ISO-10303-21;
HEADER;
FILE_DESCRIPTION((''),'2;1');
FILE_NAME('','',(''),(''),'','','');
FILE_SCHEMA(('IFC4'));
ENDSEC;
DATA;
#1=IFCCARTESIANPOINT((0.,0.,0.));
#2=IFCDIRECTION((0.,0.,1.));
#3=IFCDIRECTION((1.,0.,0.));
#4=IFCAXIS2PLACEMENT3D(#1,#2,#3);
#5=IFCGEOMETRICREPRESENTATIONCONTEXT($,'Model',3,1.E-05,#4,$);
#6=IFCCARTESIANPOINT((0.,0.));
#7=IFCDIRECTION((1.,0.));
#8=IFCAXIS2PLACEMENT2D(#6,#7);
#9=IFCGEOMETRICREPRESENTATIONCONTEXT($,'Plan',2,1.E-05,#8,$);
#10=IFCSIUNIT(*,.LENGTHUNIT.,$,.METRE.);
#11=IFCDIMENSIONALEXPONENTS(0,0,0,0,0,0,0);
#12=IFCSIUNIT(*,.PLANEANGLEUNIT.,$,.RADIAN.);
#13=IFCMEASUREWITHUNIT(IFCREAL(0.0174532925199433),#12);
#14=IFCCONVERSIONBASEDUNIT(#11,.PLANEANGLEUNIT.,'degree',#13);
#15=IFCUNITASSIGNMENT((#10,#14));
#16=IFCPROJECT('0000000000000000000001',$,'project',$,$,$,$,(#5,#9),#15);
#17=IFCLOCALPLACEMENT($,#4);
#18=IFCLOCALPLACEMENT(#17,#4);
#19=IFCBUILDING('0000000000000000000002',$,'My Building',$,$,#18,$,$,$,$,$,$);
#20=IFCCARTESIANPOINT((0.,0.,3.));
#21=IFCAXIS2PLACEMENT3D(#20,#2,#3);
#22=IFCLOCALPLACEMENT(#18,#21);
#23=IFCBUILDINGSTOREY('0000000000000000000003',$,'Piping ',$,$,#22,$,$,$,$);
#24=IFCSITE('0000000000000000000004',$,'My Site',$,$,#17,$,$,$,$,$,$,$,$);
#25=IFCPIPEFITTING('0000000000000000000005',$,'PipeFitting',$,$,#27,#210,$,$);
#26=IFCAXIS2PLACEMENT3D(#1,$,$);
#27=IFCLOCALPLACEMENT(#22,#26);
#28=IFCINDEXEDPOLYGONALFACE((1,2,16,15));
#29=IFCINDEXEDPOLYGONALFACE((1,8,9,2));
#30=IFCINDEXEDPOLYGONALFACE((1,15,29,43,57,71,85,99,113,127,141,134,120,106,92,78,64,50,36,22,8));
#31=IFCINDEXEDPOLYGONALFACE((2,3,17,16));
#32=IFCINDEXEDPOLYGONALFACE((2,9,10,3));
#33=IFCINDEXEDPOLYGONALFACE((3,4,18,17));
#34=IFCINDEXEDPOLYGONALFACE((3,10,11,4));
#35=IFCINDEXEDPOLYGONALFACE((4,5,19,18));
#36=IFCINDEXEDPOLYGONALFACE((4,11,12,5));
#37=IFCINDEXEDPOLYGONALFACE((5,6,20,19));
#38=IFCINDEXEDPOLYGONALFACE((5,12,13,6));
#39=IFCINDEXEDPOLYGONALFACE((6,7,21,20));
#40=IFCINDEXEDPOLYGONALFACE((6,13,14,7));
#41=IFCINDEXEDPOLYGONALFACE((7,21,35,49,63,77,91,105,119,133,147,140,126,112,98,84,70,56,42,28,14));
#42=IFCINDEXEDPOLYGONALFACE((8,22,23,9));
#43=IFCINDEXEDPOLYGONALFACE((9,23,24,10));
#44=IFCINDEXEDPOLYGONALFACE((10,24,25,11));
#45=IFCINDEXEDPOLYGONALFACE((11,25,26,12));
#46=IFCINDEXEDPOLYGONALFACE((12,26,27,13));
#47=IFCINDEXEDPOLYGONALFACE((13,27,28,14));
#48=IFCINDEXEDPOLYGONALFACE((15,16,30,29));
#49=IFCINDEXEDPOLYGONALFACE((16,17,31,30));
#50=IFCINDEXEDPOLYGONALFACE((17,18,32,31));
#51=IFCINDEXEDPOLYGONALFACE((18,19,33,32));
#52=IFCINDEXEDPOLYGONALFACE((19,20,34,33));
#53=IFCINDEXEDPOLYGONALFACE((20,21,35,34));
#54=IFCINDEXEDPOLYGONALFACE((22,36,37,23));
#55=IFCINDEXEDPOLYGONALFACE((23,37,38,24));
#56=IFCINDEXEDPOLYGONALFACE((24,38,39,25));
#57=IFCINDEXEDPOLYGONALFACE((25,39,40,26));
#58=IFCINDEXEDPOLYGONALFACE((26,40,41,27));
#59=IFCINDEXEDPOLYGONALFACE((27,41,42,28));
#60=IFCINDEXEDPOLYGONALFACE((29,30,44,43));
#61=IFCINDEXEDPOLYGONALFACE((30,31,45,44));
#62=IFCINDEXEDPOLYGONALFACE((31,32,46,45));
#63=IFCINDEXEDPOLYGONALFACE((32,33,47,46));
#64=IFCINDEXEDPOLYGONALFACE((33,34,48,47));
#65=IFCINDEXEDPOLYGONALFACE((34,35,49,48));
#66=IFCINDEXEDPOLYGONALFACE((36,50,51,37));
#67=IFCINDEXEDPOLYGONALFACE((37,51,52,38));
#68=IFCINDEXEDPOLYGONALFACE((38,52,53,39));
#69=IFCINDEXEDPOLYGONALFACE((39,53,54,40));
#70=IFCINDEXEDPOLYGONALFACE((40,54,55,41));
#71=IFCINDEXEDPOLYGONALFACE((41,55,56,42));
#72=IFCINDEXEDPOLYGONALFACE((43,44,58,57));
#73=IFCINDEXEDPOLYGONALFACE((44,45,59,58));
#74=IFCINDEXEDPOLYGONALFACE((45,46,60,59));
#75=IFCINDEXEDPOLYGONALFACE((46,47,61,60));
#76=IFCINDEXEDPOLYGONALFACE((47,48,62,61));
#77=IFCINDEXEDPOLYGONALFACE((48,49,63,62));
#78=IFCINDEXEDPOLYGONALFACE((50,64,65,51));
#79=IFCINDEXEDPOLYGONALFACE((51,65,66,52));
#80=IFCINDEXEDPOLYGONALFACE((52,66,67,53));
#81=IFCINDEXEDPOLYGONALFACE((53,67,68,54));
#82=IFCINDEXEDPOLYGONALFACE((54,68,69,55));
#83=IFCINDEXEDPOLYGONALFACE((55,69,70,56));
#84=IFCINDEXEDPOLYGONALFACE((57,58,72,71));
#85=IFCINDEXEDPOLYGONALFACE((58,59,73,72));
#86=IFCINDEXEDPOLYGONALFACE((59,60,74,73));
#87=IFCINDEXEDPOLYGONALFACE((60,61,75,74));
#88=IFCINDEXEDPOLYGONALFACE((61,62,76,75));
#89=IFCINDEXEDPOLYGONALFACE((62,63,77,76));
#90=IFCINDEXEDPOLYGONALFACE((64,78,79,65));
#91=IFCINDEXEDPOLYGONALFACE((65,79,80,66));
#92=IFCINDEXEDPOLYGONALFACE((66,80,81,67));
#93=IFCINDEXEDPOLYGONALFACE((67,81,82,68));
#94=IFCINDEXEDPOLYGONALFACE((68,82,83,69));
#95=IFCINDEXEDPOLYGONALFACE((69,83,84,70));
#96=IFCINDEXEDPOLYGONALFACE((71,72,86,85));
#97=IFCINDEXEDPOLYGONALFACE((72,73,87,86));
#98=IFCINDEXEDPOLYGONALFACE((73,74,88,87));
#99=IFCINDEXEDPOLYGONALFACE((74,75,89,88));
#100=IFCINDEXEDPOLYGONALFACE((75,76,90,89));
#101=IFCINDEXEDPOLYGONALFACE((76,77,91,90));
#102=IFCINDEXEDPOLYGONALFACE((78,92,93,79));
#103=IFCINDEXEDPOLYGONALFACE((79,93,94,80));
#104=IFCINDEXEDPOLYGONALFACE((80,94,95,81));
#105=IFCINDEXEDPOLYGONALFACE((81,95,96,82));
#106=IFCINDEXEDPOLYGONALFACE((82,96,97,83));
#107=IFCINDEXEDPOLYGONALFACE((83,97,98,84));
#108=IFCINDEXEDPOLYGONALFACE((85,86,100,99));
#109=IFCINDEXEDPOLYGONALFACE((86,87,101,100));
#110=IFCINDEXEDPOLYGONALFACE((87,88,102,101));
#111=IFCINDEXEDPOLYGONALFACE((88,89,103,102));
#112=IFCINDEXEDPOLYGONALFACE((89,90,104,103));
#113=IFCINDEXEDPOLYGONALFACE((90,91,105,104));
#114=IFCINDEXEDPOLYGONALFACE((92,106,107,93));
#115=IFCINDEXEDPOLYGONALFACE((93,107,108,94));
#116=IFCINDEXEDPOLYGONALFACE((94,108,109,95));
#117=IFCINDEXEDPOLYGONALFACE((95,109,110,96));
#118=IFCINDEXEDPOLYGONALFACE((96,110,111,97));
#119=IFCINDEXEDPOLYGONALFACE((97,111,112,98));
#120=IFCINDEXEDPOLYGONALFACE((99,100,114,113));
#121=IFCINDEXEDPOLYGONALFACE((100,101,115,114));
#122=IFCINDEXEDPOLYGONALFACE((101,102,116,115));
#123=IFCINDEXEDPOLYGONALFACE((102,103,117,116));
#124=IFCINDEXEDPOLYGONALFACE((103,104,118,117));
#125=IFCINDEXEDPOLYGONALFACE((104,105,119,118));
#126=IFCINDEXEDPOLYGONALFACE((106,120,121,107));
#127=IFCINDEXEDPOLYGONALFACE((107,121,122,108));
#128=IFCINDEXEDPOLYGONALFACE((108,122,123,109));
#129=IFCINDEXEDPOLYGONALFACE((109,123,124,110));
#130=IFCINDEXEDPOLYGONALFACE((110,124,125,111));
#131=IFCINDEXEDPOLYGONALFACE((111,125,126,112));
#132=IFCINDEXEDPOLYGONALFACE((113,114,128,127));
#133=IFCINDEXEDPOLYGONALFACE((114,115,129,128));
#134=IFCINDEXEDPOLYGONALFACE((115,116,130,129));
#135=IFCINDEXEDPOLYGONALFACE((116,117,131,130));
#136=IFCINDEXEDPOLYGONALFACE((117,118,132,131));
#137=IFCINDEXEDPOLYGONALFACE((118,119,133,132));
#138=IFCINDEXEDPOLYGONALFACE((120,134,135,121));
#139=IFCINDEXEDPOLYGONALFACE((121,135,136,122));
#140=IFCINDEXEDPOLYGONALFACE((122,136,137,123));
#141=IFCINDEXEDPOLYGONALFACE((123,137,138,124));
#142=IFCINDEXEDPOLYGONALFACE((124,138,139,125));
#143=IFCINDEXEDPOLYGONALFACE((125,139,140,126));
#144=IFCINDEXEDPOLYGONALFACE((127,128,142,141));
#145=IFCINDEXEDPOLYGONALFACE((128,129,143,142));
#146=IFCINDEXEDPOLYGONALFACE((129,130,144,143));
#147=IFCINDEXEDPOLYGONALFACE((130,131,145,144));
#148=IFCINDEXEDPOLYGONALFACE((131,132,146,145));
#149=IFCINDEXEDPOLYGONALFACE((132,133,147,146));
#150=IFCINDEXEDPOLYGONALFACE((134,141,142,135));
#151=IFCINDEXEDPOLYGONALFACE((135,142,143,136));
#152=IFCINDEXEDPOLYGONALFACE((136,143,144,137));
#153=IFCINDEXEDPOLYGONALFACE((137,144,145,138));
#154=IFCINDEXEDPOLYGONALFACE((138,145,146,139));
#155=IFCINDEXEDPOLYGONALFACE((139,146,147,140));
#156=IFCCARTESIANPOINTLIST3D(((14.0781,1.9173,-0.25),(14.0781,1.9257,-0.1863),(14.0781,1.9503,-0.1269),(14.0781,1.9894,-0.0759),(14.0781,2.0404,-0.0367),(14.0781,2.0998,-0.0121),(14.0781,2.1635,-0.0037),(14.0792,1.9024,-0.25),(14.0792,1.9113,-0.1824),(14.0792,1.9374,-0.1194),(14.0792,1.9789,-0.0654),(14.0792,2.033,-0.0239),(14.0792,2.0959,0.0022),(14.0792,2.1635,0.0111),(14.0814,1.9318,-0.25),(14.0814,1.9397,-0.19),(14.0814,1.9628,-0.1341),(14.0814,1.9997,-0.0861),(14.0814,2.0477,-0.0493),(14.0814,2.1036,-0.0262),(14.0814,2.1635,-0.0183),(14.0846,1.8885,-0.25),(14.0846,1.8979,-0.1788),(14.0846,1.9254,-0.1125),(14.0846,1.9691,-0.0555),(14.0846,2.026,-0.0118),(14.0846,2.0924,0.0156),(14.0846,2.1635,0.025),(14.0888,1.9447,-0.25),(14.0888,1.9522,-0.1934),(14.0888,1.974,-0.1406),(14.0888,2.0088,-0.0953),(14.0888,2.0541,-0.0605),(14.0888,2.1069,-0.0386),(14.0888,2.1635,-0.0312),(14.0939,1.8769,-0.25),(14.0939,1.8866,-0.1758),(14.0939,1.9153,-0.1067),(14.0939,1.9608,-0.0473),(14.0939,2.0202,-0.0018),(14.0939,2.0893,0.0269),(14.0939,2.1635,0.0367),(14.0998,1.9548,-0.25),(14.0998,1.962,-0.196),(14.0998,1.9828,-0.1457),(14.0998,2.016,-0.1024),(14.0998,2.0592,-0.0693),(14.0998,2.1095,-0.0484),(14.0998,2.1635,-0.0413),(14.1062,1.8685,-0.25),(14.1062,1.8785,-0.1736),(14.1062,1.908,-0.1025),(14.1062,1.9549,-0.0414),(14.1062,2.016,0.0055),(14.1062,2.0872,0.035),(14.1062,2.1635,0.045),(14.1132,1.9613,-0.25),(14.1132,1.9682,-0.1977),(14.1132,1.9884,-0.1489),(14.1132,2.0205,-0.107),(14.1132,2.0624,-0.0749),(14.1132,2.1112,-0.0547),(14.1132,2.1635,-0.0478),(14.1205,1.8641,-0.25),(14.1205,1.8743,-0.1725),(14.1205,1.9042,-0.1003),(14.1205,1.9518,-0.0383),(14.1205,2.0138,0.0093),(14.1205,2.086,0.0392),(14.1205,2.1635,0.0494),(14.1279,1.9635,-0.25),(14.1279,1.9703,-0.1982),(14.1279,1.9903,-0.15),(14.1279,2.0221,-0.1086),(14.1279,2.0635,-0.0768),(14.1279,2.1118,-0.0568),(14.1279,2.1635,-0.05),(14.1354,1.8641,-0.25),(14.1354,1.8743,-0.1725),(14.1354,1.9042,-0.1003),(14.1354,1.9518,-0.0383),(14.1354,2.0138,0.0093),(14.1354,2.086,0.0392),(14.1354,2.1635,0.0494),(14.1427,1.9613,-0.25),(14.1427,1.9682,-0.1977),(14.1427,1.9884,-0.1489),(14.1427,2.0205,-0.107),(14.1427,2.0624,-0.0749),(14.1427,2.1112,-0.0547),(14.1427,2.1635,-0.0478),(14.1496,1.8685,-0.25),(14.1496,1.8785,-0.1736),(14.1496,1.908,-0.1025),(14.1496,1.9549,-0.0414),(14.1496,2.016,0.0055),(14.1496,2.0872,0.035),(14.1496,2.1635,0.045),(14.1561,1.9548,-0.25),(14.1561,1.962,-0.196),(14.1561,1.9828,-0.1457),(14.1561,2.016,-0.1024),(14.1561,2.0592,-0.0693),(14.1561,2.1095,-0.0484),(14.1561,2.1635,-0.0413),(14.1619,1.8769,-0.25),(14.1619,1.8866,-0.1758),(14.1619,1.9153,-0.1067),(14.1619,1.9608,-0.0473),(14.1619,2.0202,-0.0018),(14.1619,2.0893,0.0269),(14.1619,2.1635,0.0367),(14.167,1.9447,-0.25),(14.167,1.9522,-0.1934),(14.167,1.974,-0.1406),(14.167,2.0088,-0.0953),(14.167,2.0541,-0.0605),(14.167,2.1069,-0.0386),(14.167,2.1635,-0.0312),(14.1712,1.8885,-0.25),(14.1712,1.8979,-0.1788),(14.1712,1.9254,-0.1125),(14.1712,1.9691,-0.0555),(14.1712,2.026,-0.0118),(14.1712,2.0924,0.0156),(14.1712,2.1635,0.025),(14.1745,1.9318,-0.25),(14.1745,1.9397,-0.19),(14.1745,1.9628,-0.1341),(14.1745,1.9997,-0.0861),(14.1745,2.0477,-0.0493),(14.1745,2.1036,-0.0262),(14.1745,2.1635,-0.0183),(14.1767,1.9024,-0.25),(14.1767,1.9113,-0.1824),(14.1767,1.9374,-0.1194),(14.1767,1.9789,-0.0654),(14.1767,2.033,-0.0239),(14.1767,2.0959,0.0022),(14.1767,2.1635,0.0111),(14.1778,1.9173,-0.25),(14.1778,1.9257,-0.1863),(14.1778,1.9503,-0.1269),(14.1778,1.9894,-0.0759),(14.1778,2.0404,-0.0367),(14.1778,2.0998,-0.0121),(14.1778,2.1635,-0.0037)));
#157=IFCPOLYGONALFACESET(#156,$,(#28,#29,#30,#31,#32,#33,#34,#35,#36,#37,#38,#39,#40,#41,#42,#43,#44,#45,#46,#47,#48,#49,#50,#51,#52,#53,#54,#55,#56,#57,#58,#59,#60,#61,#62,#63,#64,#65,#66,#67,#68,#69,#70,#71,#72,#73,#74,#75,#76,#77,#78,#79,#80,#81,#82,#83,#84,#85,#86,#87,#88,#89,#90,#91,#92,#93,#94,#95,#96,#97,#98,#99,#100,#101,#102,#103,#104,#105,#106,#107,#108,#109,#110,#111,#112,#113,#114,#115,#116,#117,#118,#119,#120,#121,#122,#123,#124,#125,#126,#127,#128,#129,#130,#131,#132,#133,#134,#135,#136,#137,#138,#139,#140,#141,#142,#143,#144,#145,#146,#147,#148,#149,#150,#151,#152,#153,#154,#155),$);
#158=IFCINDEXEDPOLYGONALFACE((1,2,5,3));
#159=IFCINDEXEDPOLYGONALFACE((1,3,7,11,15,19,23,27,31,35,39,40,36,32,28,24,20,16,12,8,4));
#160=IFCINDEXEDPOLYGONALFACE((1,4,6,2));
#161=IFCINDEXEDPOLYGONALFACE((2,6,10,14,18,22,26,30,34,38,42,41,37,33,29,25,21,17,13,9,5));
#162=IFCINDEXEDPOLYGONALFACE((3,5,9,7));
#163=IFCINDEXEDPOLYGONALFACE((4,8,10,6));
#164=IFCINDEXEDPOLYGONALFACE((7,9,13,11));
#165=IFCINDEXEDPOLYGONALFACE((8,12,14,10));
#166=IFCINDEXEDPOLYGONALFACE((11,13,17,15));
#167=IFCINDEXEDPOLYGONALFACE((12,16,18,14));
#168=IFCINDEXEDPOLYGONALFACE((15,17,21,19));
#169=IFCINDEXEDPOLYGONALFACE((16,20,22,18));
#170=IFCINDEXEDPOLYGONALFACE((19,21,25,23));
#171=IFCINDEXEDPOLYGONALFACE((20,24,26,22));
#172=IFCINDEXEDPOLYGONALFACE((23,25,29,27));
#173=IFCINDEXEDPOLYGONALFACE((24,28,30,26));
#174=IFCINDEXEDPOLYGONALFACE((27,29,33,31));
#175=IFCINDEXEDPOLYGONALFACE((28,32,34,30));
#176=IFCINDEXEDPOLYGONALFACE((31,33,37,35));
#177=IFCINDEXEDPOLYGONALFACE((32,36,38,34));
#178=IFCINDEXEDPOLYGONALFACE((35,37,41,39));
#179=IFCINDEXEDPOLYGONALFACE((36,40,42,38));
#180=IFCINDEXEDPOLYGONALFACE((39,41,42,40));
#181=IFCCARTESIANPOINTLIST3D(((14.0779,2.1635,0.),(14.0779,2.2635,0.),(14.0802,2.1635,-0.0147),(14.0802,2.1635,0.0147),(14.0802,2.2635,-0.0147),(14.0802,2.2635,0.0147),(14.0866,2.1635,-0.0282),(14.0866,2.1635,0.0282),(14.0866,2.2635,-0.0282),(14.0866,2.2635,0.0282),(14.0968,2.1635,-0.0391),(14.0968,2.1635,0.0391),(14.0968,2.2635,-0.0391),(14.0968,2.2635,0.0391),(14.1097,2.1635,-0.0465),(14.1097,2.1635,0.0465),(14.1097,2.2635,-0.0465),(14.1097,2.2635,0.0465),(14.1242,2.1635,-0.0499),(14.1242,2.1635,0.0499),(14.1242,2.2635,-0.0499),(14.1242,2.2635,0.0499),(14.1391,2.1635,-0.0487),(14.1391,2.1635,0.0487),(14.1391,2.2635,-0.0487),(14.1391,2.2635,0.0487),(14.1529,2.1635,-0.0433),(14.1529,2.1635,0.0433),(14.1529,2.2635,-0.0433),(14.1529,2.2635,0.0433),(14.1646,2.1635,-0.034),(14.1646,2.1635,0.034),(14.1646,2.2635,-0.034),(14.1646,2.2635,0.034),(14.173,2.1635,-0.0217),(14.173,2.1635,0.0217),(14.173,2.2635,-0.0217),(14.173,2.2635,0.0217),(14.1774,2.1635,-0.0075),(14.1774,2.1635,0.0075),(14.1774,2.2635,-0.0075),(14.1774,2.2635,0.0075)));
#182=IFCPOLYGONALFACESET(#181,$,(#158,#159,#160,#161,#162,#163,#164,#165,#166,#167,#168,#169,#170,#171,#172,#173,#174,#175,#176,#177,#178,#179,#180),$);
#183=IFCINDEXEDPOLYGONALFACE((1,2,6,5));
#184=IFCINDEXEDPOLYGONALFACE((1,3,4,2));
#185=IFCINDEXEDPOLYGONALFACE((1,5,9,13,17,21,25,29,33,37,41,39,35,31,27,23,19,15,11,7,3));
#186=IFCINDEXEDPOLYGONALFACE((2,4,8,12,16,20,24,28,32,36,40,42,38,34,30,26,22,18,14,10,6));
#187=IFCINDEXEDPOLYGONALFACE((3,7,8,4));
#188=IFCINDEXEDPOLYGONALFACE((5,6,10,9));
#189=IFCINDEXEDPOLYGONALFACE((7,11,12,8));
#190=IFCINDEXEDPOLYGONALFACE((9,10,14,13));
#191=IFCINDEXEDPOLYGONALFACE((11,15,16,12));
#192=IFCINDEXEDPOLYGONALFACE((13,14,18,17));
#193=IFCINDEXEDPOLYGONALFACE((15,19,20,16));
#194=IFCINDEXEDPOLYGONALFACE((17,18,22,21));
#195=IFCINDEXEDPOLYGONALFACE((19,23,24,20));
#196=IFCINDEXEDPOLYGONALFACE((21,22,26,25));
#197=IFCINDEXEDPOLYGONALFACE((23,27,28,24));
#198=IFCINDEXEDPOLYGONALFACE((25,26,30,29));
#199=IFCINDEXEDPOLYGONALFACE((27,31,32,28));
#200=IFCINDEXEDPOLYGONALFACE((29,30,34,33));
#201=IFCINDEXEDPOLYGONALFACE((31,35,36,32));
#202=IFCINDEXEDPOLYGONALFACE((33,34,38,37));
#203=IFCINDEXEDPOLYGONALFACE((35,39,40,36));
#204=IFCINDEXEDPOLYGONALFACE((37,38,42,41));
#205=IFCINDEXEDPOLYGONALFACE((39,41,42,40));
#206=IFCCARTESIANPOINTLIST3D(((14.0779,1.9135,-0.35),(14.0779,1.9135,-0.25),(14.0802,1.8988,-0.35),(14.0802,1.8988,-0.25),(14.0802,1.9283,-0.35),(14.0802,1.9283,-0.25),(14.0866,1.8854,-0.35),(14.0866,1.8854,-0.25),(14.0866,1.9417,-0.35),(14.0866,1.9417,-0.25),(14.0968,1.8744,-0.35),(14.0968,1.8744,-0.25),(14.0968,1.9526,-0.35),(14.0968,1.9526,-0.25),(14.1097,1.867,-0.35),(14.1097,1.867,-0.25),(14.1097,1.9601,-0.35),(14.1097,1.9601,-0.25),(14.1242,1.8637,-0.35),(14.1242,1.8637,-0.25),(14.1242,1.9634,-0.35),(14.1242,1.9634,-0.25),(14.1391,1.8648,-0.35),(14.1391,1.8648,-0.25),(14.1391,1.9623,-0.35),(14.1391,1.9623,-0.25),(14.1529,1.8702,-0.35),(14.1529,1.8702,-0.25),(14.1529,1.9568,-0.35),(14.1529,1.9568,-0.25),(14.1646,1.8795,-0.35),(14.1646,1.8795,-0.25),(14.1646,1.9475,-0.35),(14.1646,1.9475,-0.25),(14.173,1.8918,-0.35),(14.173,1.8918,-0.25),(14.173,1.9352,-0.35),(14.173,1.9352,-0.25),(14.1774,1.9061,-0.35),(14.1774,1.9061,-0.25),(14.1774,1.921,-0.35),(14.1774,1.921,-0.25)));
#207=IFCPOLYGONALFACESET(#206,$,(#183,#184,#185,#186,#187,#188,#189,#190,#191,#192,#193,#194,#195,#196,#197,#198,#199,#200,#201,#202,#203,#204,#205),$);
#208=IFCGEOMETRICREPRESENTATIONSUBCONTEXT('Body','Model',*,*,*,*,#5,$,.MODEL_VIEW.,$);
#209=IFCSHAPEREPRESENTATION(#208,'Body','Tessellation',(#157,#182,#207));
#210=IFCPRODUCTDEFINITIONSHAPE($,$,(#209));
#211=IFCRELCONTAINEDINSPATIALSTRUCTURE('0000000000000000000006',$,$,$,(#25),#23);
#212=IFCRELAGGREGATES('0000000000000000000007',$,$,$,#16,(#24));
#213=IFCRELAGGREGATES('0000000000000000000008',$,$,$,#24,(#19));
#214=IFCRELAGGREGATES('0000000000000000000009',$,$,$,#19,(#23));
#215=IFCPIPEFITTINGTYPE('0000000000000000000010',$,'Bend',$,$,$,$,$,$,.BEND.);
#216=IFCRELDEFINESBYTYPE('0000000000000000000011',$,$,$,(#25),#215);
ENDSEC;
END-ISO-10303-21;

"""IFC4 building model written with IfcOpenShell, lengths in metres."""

from ifc_helpers import new_model, entity, si_unit, converted_unit, frame, origin_with_axes, origin_2d_with_axis, place, context, subcontext, project, spatial, circle, extrude, source, transform, mapped, type_object, type_shapes, element, save


model = new_model("IFC4")

# Units and contexts
model_context = context("Model", 3, precision=1e-05, world=origin_with_axes())
plan_context = context("Plan", 2, precision=1e-05, world=origin_2d_with_axis())
body_context = subcontext(model_context, "Body", "Model", "MODEL_VIEW")
ifc_project = project(units=[si_unit("LENGTHUNIT", "METRE"), converted_unit("PLANEANGLEUNIT", "degree", entity("IfcReal", 0.0174532925199433), si_unit("PLANEANGLEUNIT", "RADIAN"), dimensions=[0, 0, 0, 0, 0, 0, 0])], contexts=[model_context, plan_context])

# Site, building, storey
site_placement = place(None, origin_with_axes())
site = spatial("IfcSite", under=ifc_project, at=site_placement, Name="My Site")
building_placement = place(site_placement, origin_with_axes())
building = spatial("IfcBuilding", under=site, at=building_placement, Name="My Building")
storey_placement = place(building_placement, frame((0.0, 0.0, 3.0), z_axis=(0.0, 0.0, 1.0), x_axis=(1.0, 0.0, 0.0)))
storey = spatial("IfcBuildingStorey", under=building, at=storey_placement, Name="Piping ")

# Pipe fitting
pipe_fitting_type = type_object("IfcPipeFittingType", Name="Bend", PredefinedType="BEND")
shared_shape = source(origin_with_axes(), body_context, "Body", "SolidModel", [
    entity("IfcSweptDiskSolid", entity("IfcIndexedPolyCurve", entity("IfcCartesianPointList3D", [[0.0, 0.0, -0.1], [0.0, -0.0732, -0.2768], [0.0, -0.25, -0.35]]), [entity("IfcArcIndex", [1, 2, 3])]), 0.05),
    extrude(circle(Radius=0.05), origin_with_axes(), (0.0, 0.0, -1.0), 0.1),
    extrude(circle(Radius=0.05), frame((0.0, -0.25, -0.35), z_axis=(0.0, -1.0, 0.0), x_axis=(1.0, 0.0, 0.0)), (0.0, 0.0, 1.0), 0.1),
])
type_shapes(pipe_fitting_type, [shared_shape])
for number, where, z_axis, x_axis, name in (
    (1, (14.1279, 2.2635, 0.0), (0.0, 1.0, 0.0), (-1.0, 0.0, 0.0), "PipeFitting"),
):
    element("IfcPipeFitting", number, at=place(storey_placement, frame(where, z_axis=z_axis, x_axis=x_axis)), inside=storey, type_object=pipe_fitting_type, Name=name, context=body_context, shape_type="MappedRepresentation", body=[
        mapped(shared_shape, transform((0.0, 0.0, 0.0), x_axis=(1.0, 0.0, 0.0), y_axis=(0.0, 1.0, 0.0), z_axis=(0.0, 0.0, 1.0), scale=1.0)),
    ])

save(model, "model.ifc")
